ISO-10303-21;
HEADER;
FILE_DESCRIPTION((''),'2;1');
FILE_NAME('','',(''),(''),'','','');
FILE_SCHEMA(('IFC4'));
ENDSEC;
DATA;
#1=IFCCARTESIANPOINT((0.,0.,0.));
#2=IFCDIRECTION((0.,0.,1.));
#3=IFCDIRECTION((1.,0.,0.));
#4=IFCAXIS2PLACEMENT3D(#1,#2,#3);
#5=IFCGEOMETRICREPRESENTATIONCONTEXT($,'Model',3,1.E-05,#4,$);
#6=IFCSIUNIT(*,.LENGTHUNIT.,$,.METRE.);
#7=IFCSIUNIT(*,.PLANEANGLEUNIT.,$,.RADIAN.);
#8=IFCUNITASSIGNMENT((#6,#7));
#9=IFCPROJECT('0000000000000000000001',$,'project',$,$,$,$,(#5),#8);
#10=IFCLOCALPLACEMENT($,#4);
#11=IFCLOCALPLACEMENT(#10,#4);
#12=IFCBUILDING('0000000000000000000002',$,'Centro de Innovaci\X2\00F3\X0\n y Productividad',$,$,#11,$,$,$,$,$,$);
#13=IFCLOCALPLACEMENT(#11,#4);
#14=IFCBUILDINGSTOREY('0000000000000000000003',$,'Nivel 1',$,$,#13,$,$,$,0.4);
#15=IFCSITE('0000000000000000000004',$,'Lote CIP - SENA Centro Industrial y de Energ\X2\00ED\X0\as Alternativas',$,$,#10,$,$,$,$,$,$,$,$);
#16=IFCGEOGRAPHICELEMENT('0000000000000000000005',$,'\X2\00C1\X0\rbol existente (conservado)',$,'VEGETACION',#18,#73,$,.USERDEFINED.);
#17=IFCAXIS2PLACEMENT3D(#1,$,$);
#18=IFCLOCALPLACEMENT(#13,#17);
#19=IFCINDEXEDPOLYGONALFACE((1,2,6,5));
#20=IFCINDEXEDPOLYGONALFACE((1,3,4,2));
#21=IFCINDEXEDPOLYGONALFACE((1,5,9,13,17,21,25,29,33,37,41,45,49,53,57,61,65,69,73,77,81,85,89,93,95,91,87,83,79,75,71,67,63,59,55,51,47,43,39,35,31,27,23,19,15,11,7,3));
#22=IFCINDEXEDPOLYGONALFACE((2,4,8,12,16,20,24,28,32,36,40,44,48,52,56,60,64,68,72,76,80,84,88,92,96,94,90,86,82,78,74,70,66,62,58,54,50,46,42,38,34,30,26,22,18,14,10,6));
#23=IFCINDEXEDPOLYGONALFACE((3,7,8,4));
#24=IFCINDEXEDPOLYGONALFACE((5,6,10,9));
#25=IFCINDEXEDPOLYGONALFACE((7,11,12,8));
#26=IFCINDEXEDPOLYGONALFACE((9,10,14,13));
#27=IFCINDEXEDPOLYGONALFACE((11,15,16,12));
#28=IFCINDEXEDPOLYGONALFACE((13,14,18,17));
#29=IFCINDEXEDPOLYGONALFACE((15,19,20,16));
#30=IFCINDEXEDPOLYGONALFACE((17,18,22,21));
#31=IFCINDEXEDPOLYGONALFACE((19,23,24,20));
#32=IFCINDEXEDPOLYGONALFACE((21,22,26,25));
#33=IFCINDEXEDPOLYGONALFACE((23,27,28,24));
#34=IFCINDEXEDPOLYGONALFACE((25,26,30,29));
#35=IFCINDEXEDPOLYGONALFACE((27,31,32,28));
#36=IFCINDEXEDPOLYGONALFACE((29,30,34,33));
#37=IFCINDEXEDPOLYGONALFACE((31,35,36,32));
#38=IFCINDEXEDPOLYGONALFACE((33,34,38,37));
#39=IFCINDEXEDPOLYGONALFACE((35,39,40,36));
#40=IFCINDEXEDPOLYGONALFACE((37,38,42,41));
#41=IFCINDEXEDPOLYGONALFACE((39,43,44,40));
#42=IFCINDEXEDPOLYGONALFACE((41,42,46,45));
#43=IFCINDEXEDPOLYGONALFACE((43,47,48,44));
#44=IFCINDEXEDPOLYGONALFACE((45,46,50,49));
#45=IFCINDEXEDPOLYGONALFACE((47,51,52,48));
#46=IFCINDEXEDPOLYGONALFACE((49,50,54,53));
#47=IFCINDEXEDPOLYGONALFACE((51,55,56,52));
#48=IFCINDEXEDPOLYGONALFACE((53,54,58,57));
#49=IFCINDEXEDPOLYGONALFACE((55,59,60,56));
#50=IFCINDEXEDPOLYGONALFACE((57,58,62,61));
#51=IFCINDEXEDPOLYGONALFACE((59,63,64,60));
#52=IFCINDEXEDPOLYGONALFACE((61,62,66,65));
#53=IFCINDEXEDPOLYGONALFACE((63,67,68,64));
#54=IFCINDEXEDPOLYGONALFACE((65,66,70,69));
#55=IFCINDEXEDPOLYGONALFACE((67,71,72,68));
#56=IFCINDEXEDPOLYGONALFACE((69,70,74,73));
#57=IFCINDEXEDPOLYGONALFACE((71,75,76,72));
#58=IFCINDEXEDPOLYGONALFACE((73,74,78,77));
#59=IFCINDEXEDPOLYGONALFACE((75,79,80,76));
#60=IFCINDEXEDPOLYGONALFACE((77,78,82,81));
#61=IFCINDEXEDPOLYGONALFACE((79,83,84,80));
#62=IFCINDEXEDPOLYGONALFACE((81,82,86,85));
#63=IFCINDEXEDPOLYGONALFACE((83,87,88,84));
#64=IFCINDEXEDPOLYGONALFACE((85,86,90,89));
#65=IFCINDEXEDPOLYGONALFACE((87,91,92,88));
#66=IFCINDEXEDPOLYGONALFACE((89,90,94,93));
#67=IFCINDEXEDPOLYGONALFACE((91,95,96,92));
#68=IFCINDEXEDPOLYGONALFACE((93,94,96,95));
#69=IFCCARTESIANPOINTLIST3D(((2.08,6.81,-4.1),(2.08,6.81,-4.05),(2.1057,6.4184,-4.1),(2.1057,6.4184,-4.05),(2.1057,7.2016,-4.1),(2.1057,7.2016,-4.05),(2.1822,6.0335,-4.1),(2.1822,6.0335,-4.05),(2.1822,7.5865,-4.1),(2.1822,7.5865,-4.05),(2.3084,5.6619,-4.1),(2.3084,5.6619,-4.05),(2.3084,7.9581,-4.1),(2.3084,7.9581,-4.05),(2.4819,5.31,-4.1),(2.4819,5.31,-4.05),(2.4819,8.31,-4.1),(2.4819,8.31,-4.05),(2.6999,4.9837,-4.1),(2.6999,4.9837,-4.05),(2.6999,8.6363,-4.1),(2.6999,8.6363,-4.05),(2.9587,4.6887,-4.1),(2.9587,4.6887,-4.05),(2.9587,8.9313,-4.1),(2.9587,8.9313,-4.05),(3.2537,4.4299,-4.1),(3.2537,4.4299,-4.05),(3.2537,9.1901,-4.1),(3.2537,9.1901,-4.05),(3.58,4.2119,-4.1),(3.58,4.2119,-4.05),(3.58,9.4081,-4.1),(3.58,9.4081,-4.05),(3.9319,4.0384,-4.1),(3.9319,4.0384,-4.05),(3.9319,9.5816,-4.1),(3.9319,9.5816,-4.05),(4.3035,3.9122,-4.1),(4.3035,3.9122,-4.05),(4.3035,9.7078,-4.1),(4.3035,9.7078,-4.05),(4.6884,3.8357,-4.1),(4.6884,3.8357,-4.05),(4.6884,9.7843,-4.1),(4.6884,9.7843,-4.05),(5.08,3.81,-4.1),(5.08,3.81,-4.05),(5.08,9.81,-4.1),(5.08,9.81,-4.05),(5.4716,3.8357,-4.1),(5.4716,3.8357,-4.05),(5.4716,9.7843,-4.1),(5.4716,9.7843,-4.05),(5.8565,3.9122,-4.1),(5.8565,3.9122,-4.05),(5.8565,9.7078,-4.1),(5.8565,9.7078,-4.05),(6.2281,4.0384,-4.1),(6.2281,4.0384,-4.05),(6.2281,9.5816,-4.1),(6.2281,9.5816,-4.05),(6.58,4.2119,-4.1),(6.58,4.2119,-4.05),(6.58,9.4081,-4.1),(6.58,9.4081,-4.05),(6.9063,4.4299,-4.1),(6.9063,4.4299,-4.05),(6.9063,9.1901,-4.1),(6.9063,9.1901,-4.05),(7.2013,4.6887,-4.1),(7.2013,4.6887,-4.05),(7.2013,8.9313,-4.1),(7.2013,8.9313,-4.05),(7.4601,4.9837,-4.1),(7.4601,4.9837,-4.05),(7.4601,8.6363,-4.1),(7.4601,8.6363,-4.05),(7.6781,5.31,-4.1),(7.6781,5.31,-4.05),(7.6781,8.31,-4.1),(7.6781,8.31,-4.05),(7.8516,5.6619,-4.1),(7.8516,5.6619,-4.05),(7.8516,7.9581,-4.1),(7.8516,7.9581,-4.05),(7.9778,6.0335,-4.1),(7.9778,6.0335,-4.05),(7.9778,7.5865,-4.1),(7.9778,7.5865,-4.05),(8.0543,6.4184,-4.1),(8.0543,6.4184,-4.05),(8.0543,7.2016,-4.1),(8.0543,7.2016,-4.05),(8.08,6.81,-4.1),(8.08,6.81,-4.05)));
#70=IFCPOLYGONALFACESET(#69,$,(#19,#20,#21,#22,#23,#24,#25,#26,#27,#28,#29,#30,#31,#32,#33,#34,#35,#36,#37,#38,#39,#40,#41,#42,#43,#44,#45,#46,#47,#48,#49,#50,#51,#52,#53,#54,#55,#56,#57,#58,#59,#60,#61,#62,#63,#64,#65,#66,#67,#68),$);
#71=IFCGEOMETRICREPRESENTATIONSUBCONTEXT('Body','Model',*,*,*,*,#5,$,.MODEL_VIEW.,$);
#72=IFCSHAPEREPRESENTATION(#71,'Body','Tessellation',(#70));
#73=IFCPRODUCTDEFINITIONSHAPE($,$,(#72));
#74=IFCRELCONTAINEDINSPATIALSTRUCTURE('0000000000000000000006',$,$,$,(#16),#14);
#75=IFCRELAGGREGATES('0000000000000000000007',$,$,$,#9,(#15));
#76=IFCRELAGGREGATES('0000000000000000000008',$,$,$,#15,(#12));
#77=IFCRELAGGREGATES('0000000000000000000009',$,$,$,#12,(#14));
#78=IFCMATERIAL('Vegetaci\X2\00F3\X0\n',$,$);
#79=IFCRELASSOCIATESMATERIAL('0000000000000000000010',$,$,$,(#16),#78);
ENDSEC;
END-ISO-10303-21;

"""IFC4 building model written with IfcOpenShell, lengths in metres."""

from ifc_helpers import new_model, si_unit, frame, origin_with_axes, place, context, subcontext, project, spatial, polyline, outline, extrude, material, element, save


model = new_model("IFC4")

# Units and contexts
model_context = context("Model", 3, precision=1e-05, world=origin_with_axes())
body_context = subcontext(model_context, "Body", "Model", "MODEL_VIEW")
ifc_project = project(units=[si_unit("LENGTHUNIT", "METRE"), si_unit("PLANEANGLEUNIT", "RADIAN")], contexts=[model_context])

# Site, building, storey
site_placement = place(None, origin_with_axes())
site = spatial("IfcSite", under=ifc_project, at=site_placement, Name="Lote CIP - SENA Centro Industrial y de Energías Alternativas")
building_placement = place(site_placement, origin_with_axes())
building = spatial("IfcBuilding", under=site, at=building_placement, Name="Centro de Innovación y Productividad")
storey_placement = place(building_placement, origin_with_axes())
storey = spatial("IfcBuildingStorey", under=building, at=storey_placement, Name="Nivel 1", Elevation=0.4)

# Geographic element
ifc_material_1 = material(Name="Vegetación")
geographic_element_1_placement = place(storey_placement, origin_with_axes())
element("IfcGeographicElement", 1, at=geographic_element_1_placement, inside=storey, material=ifc_material_1, Name="Árbol existente (conservado)", ObjectType="VEGETACION", PredefinedType="USERDEFINED", context=body_context, shape_type="SweptSolid", body=[
    extrude(outline(polyline([(8.08, 6.81), (8.0543, 6.4184), (7.9778, 6.0335), (7.8516, 5.6619), (7.6781, 5.31), (7.4601, 4.9837), (7.2013, 4.6887), (6.9063, 4.4299), (6.58, 4.2119), (6.2281, 4.0384), (5.8565, 3.9122), (5.4716, 3.8357), (5.08, 3.81), (4.6884, 3.8357), (4.3035, 3.9122), (3.9319, 4.0384), (3.58, 4.2119), (3.2537, 4.4299), (2.9587, 4.6887), (2.6999, 4.9837), (2.4819, 5.31), (2.3084, 5.6619), (2.1822, 6.0335), (2.1057, 6.4184), (2.08, 6.81), (2.1057, 7.2016), (2.1822, 7.5865), (2.3084, 7.9581), (2.4819, 8.31), (2.6999, 8.6363), (2.9587, 8.9313), (3.2537, 9.1901), (3.58, 9.4081), (3.9319, 9.5816), (4.3035, 9.7078), (4.6884, 9.7843), (5.08, 9.81), (5.4716, 9.7843), (5.8565, 9.7078), (6.2281, 9.5816), (6.58, 9.4081), (6.9063, 9.1901), (7.2013, 8.9313), (7.4601, 8.6363), (7.6781, 8.31), (7.8516, 7.9581), (7.9778, 7.5865), (8.0543, 7.2016), (8.08, 6.81)])), frame((0.0, 0.0, -4.1)), (0.0, 0.0, 1.0), 0.05),
])

save(model, "model.ifc")
